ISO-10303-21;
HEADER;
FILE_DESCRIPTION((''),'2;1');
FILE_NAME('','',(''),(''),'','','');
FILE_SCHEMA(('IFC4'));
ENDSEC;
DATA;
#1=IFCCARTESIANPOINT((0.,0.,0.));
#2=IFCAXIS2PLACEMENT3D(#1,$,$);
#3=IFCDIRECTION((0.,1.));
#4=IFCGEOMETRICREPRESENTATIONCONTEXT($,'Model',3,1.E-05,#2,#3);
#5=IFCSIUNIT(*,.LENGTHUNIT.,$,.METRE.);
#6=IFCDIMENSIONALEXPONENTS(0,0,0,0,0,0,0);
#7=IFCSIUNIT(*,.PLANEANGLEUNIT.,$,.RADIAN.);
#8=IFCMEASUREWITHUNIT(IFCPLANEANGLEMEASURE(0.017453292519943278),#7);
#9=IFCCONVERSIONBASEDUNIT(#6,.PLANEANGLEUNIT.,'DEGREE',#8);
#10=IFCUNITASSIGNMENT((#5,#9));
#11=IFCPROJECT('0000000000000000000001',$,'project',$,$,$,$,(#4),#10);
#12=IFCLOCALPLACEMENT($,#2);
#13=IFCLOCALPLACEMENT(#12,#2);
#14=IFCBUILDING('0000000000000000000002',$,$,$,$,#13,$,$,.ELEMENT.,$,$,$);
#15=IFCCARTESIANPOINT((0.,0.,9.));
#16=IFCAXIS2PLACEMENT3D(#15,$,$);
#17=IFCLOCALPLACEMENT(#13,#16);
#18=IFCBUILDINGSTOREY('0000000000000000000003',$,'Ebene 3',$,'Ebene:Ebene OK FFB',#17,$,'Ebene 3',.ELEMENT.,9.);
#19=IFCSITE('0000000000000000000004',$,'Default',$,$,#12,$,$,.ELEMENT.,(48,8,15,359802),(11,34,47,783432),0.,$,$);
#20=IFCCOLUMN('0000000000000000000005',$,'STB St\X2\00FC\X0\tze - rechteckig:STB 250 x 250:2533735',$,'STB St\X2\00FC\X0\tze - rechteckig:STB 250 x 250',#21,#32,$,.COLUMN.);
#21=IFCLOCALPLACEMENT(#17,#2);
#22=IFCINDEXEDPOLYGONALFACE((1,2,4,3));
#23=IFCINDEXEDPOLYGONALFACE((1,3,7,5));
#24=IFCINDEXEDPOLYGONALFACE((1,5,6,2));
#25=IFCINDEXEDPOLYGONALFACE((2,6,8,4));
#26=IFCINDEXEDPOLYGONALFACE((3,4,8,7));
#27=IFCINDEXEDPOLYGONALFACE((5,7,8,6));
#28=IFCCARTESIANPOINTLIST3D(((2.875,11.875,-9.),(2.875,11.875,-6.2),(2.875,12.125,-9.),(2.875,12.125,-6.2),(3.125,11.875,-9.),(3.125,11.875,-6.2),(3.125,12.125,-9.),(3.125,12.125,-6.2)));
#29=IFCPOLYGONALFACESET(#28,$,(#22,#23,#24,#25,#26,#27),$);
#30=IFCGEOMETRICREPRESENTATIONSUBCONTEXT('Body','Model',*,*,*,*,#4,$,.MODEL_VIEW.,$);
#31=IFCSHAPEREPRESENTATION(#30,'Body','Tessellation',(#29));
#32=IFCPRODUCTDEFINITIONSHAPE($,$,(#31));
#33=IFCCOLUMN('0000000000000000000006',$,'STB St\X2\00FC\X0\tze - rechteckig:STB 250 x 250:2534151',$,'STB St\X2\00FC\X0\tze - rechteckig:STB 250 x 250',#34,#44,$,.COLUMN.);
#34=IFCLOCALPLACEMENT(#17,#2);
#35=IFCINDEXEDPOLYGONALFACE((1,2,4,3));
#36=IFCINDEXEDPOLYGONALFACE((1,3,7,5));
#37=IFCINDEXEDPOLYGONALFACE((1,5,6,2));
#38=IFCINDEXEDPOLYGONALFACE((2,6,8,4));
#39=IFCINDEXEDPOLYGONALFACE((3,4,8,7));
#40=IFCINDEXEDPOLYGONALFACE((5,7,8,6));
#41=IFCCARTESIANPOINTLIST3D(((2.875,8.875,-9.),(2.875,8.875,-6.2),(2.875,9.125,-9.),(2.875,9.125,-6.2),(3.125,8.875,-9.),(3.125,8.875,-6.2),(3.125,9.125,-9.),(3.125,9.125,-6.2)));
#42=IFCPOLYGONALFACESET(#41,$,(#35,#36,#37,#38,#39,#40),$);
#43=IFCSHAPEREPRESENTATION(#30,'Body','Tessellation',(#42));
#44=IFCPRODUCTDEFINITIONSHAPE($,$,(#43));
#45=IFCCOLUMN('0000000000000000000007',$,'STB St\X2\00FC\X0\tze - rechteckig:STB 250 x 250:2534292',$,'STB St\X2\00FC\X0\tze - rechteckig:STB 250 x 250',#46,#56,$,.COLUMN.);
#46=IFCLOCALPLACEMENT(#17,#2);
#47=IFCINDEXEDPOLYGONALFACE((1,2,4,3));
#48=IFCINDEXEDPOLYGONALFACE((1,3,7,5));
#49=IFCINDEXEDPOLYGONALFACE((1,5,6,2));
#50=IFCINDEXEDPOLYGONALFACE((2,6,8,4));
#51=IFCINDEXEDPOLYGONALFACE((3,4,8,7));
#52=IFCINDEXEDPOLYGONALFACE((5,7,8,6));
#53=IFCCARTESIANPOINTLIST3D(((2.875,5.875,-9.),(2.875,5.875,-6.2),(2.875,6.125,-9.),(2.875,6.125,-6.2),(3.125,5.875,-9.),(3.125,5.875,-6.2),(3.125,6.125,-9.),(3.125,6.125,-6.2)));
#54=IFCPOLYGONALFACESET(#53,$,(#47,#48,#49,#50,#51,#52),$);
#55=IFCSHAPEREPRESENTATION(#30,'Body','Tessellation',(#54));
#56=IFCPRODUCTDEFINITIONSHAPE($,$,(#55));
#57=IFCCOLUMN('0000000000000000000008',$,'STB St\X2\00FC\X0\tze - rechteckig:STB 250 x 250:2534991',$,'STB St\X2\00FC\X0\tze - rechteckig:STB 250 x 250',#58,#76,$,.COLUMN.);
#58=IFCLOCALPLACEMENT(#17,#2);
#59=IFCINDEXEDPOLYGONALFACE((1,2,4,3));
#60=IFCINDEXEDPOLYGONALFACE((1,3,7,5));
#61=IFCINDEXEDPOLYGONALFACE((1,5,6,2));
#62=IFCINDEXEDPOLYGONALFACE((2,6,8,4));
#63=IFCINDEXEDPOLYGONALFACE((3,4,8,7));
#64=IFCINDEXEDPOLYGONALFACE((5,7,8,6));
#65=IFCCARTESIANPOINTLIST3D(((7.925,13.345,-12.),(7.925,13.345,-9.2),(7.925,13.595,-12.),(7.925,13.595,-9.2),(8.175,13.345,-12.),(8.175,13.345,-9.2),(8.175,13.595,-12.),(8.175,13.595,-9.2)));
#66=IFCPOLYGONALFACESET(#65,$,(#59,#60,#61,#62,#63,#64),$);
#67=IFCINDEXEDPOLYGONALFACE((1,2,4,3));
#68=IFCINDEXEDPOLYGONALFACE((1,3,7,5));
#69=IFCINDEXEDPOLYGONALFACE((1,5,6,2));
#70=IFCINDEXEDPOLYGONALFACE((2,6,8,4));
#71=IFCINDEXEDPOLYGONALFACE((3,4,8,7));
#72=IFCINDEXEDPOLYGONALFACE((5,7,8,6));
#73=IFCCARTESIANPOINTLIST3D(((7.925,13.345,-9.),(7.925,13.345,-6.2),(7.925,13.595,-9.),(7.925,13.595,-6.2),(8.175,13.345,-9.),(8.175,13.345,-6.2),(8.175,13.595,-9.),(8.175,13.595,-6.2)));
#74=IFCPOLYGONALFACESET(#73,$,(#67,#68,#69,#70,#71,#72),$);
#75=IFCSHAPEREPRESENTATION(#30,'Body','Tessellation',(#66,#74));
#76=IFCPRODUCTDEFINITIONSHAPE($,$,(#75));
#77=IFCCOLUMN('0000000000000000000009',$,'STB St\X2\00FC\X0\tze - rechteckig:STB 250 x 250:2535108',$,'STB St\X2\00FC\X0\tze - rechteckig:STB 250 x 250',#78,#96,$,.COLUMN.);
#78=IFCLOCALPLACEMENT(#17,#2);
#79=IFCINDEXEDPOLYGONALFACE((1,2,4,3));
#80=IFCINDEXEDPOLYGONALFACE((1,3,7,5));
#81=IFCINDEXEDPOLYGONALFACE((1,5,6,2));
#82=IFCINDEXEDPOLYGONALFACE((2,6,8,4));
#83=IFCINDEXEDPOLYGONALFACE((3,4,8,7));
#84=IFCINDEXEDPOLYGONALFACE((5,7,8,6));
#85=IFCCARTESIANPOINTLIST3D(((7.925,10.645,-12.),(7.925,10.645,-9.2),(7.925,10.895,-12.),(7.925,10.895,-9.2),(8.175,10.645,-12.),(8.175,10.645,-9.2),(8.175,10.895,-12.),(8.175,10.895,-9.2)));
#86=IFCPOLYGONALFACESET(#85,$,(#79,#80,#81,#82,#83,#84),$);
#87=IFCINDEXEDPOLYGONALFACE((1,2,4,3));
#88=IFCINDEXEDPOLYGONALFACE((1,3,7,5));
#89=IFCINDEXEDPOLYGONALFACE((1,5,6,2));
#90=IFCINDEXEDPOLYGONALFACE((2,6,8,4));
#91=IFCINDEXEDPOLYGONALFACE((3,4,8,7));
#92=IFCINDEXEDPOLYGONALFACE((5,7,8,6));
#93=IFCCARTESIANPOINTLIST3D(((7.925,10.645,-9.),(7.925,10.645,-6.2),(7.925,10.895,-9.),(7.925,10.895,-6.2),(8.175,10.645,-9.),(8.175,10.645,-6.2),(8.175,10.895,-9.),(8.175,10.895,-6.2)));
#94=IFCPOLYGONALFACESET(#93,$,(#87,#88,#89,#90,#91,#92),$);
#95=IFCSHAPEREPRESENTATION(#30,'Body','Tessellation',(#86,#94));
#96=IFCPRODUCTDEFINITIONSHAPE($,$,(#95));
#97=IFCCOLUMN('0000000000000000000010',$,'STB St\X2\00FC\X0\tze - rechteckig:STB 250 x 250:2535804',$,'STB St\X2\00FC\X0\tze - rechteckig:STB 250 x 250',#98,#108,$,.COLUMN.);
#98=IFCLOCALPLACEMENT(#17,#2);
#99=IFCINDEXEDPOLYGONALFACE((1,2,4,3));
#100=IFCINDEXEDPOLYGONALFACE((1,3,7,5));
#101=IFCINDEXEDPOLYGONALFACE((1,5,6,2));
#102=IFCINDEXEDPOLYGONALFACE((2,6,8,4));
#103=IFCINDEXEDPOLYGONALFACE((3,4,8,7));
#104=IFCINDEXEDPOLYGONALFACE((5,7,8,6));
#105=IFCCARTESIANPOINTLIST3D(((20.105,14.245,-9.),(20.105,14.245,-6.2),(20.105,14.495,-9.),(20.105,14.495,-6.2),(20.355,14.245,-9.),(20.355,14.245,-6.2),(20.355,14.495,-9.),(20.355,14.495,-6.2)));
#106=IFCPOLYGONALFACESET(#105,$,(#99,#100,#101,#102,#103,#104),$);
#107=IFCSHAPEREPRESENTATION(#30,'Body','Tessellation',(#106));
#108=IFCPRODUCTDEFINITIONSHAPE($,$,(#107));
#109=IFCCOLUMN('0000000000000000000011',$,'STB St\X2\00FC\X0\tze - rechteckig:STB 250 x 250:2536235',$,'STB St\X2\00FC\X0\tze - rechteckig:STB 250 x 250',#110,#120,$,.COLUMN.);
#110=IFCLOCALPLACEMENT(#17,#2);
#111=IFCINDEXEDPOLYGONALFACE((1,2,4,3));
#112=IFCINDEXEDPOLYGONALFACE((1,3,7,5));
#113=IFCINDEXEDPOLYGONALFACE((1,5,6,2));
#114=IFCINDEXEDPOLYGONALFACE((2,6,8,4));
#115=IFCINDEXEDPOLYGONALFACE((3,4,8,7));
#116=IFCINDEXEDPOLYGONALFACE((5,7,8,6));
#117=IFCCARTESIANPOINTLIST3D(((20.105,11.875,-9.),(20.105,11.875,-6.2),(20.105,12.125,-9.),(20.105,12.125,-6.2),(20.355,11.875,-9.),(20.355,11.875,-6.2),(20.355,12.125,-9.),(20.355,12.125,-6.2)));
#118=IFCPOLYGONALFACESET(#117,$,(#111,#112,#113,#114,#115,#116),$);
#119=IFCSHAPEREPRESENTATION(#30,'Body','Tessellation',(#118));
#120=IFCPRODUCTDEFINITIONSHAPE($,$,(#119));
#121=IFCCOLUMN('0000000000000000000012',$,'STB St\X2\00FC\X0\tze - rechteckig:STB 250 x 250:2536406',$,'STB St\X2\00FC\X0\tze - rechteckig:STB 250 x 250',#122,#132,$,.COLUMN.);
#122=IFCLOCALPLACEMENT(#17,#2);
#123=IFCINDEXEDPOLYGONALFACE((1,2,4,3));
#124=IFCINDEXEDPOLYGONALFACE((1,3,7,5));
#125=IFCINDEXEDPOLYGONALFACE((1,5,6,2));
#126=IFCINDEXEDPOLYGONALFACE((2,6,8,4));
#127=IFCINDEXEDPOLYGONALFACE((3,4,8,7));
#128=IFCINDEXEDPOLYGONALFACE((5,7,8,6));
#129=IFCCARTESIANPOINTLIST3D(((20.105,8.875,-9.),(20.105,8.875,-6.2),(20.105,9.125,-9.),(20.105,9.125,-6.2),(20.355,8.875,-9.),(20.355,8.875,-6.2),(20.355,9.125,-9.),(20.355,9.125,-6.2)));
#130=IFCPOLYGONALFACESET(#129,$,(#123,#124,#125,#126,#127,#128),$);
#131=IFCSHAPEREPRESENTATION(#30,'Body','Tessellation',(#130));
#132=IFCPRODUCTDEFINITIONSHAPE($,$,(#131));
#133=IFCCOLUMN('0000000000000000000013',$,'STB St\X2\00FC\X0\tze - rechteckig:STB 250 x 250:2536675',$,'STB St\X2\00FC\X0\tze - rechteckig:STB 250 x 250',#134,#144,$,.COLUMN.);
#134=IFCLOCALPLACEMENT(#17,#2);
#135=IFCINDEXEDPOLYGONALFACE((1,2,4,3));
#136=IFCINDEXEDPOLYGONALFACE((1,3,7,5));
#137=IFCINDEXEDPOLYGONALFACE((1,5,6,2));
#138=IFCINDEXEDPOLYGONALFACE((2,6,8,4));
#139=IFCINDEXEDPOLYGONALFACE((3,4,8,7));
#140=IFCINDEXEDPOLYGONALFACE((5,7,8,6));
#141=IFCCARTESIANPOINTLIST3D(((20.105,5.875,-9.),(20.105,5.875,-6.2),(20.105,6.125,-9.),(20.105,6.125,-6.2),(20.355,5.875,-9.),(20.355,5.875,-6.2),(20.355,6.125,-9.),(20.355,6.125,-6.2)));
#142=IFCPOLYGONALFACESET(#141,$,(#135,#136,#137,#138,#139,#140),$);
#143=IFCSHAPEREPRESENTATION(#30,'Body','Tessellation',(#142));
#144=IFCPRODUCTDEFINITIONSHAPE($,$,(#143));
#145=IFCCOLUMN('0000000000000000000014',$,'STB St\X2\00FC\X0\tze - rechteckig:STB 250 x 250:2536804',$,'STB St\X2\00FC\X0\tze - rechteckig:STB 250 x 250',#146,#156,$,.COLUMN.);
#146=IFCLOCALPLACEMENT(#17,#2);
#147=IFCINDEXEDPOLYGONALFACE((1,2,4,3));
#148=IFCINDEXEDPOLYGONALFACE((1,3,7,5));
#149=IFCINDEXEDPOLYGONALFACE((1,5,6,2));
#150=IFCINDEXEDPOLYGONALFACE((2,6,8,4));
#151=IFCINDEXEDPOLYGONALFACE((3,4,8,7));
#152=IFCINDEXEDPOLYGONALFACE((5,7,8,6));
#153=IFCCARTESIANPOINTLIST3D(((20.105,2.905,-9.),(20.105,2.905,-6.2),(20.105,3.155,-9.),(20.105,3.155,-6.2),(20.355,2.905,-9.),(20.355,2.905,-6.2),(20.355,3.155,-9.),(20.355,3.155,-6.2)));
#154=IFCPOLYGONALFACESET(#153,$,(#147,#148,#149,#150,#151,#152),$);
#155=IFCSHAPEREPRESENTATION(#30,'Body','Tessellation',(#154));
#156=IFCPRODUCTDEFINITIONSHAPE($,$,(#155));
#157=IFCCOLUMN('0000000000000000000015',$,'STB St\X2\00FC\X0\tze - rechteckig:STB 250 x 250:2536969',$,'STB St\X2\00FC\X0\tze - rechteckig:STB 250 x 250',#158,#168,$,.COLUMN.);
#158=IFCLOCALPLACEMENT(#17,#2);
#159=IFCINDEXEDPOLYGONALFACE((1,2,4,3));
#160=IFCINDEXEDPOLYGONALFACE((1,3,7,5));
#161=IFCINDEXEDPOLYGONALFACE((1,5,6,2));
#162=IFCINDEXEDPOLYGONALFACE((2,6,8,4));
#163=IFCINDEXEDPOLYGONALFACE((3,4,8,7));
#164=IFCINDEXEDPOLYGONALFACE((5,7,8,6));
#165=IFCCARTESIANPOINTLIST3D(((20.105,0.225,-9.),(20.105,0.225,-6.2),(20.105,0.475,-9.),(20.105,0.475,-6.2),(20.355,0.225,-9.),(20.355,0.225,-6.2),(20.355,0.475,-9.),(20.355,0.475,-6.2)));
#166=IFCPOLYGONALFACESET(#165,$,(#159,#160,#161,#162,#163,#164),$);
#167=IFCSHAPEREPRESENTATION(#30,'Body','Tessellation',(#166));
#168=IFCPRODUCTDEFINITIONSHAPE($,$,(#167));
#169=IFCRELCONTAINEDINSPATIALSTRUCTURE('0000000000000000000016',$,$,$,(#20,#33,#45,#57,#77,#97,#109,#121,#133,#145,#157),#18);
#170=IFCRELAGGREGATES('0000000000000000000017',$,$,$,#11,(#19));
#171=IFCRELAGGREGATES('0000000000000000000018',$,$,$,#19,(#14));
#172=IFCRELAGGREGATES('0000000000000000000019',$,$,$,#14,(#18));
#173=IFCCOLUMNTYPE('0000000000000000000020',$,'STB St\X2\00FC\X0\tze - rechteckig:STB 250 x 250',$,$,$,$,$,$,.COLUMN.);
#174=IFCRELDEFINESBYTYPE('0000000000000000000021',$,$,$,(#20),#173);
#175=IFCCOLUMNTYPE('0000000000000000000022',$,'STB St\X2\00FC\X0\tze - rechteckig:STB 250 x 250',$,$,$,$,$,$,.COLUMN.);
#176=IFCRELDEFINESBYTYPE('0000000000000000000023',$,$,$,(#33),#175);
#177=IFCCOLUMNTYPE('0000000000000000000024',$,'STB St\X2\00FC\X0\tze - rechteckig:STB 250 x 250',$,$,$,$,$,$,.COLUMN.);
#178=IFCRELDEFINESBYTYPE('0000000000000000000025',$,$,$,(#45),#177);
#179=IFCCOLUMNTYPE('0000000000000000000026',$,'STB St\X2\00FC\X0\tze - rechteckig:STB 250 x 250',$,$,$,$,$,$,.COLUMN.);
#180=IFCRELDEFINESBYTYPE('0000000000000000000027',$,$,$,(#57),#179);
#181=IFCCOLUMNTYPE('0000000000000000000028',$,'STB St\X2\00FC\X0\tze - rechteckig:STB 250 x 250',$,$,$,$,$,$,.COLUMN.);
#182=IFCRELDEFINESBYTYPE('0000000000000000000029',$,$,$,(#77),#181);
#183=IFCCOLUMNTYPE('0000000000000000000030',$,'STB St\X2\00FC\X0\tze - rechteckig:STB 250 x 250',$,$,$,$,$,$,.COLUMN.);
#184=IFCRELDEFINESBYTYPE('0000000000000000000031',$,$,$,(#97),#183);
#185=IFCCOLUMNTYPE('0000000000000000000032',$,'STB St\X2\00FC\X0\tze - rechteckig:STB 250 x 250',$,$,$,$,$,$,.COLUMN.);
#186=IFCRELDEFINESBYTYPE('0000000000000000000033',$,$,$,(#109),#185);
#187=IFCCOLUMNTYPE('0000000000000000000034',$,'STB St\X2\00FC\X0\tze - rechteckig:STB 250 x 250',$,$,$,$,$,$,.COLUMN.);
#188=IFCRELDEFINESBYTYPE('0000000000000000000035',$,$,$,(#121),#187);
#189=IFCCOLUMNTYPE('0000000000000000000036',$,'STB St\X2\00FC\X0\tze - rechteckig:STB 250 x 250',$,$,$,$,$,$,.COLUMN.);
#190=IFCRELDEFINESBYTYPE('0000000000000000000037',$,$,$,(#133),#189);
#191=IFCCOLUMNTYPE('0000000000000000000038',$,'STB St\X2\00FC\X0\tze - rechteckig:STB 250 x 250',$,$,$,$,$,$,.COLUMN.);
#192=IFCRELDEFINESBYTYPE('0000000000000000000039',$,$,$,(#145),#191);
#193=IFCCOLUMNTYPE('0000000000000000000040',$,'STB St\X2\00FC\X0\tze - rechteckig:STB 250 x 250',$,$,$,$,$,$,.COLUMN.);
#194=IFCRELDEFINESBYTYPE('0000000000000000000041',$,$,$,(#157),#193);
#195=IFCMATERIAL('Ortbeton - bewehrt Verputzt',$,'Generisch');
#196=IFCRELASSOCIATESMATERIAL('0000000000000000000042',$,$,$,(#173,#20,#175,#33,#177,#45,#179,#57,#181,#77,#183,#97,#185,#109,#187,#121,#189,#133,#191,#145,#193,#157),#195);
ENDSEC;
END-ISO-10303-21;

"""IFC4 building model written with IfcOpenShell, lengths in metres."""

from ifc_helpers import new_model, entity, si_unit, converted_unit, direction, frame, origin, place, context, subcontext, project, spatial, indexed_curve, outline, extrude, source, transform, mapped, material, type_object, type_shapes, element, save


model = new_model("IFC4")

# Units and contexts
model_context = context("Model", 3, precision=1e-05, world=origin(), true_north=direction((0.0, 1.0)))
body_context = subcontext(model_context, "Body", "Model", "MODEL_VIEW")
ifc_project = project(units=[si_unit("LENGTHUNIT", "METRE"), converted_unit("PLANEANGLEUNIT", "DEGREE", entity("IfcPlaneAngleMeasure", 0.017453292519943278), si_unit("PLANEANGLEUNIT", "RADIAN"), dimensions=[0, 0, 0, 0, 0, 0, 0])], contexts=[model_context])

# Site, building, storey
site_placement = place(None, origin())
site = spatial("IfcSite", under=ifc_project, at=site_placement, Name="Default", CompositionType="ELEMENT", RefLatitude=(48, 8, 15, 359802), RefLongitude=(11, 34, 47, 783432), RefElevation=0.0)
building_placement = place(site_placement, origin())
building = spatial("IfcBuilding", under=site, at=building_placement, CompositionType="ELEMENT")
storey_placement = place(building_placement, frame((0.0, 0.0, 9.0)))
storey = spatial("IfcBuildingStorey", under=building, at=storey_placement, Name="Ebene 3", ObjectType="Ebene:Ebene OK FFB", LongName="Ebene 3", CompositionType="ELEMENT", Elevation=9.0)

# Columns
ifc_material_1 = material(Name="Ortbeton - bewehrt Verputzt", Category="Generisch")
column_type_1 = type_object("IfcColumnType", Name="STB Stütze - rechteckig:STB 250 x 250", PredefinedType="COLUMN", material=ifc_material_1)
shared_shape_1 = source(origin(), body_context, "Body", "SweptSolid", [
    extrude(outline(indexed_curve([(-0.125, -0.125), (0.125, -0.125), (0.125, 0.125), (-0.125, 0.125), (-0.125, -0.125)], self_intersect=False)), frame((3.0, 12.0, 0.0), z_axis=(0.0, 0.0, 1.0), x_axis=(-1.0, 0.0, 0.0)), (0.0, 0.0, 1.0), 2.8),
])
type_shapes(column_type_1, [shared_shape_1])
column_1_placement = place(storey_placement, frame((0.0, 0.0, -9.0)))
element("IfcColumn", 1, at=column_1_placement, inside=storey, type_object=column_type_1, material=ifc_material_1, Name="STB Stütze - rechteckig:STB 250 x 250:2533735", ObjectType="STB Stütze - rechteckig:STB 250 x 250", PredefinedType="COLUMN", context=body_context, shape_type="MappedRepresentation", body=[
    mapped(shared_shape_1, transform((0.0, 0.0, 0.0), scale=1.0)),
])
column_type_2 = type_object("IfcColumnType", Name="STB Stütze - rechteckig:STB 250 x 250", PredefinedType="COLUMN", material=ifc_material_1)
shared_shape_2 = source(origin(), body_context, "Body", "SweptSolid", [
    extrude(outline(indexed_curve([(-0.125, -0.125), (0.125, -0.125), (0.125, 0.125), (-0.125, 0.125), (-0.125, -0.125)], self_intersect=False)), frame((3.0, 9.0, 0.0), z_axis=(0.0, 0.0, 1.0), x_axis=(-1.0, 0.0, 0.0)), (0.0, 0.0, 1.0), 2.8),
])
type_shapes(column_type_2, [shared_shape_2])
column_2_placement = place(storey_placement, frame((0.0, 0.0, -9.0)))
element("IfcColumn", 2, at=column_2_placement, inside=storey, type_object=column_type_2, material=ifc_material_1, Name="STB Stütze - rechteckig:STB 250 x 250:2534151", ObjectType="STB Stütze - rechteckig:STB 250 x 250", PredefinedType="COLUMN", context=body_context, shape_type="MappedRepresentation", body=[
    mapped(shared_shape_2, transform((0.0, 0.0, 0.0), scale=1.0)),
])
column_type_3 = type_object("IfcColumnType", Name="STB Stütze - rechteckig:STB 250 x 250", PredefinedType="COLUMN", material=ifc_material_1)
shared_shape_3 = source(origin(), body_context, "Body", "SweptSolid", [
    extrude(outline(indexed_curve([(-0.125, -0.125), (0.125, -0.125), (0.125, 0.125), (-0.125, 0.125), (-0.125, -0.125)], self_intersect=False)), frame((3.0, 6.0, 0.0), z_axis=(0.0, 0.0, 1.0), x_axis=(-1.0, 0.0, 0.0)), (0.0, 0.0, 1.0), 2.8),
])
type_shapes(column_type_3, [shared_shape_3])
column_3_placement = place(storey_placement, frame((0.0, 0.0, -9.0)))
element("IfcColumn", 3, at=column_3_placement, inside=storey, type_object=column_type_3, material=ifc_material_1, Name="STB Stütze - rechteckig:STB 250 x 250:2534292", ObjectType="STB Stütze - rechteckig:STB 250 x 250", PredefinedType="COLUMN", context=body_context, shape_type="MappedRepresentation", body=[
    mapped(shared_shape_3, transform((0.0, 0.0, 0.0), scale=1.0)),
])
column_type_4 = type_object("IfcColumnType", Name="STB Stütze - rechteckig:STB 250 x 250", PredefinedType="COLUMN", material=ifc_material_1)
shared_shape_4 = source(origin(), body_context, "Body", "SweptSolid", [
    extrude(outline(indexed_curve([(-0.125, -0.125), (0.125, -0.125), (0.125, 0.125), (-0.125, 0.125), (-0.125, -0.125)], self_intersect=False)), frame((8.05, 13.47, -3.0), z_axis=(0.0, 0.0, 1.0), x_axis=(-1.0, 0.0, 0.0)), (0.0, 0.0, 1.0), 2.8),
    extrude(outline(indexed_curve([(-0.125, -0.125), (0.125, -0.125), (0.125, 0.125), (-0.125, 0.125), (-0.125, -0.125)], self_intersect=False)), frame((8.05, 13.47, 0.0), z_axis=(0.0, 0.0, 1.0), x_axis=(0.0, -1.0, 0.0)), (0.0, 0.0, 1.0), 2.8),
])
type_shapes(column_type_4, [shared_shape_4])
column_4_placement = place(storey_placement, frame((0.0, 0.0, -9.0)))
element("IfcColumn", 4, at=column_4_placement, inside=storey, type_object=column_type_4, material=ifc_material_1, Name="STB Stütze - rechteckig:STB 250 x 250:2534991", ObjectType="STB Stütze - rechteckig:STB 250 x 250", PredefinedType="COLUMN", context=body_context, shape_type="MappedRepresentation", body=[
    mapped(shared_shape_4, transform((0.0, 0.0, 0.0), scale=1.0)),
])
column_type_5 = type_object("IfcColumnType", Name="STB Stütze - rechteckig:STB 250 x 250", PredefinedType="COLUMN", material=ifc_material_1)
shared_shape_5 = source(origin(), body_context, "Body", "SweptSolid", [
    extrude(outline(indexed_curve([(-0.125, -0.125), (0.125, -0.125), (0.125, 0.125), (-0.125, 0.125), (-0.125, -0.125)], self_intersect=False)), frame((8.05, 10.77, -3.0), z_axis=(0.0, 0.0, 1.0), x_axis=(-1.0, 0.0, 0.0)), (0.0, 0.0, 1.0), 2.8),
    extrude(outline(indexed_curve([(-0.125, -0.125), (0.125, -0.125), (0.125, 0.125), (-0.125, 0.125), (-0.125, -0.125)], self_intersect=False)), frame((8.05, 10.77, 0.0), z_axis=(0.0, 0.0, 1.0), x_axis=(0.0, -1.0, 0.0)), (0.0, 0.0, 1.0), 2.8),
])
type_shapes(column_type_5, [shared_shape_5])
column_5_placement = place(storey_placement, frame((0.0, 0.0, -9.0)))
element("IfcColumn", 5, at=column_5_placement, inside=storey, type_object=column_type_5, material=ifc_material_1, Name="STB Stütze - rechteckig:STB 250 x 250:2535108", ObjectType="STB Stütze - rechteckig:STB 250 x 250", PredefinedType="COLUMN", context=body_context, shape_type="MappedRepresentation", body=[
    mapped(shared_shape_5, transform((0.0, 0.0, 0.0), scale=1.0)),
])
column_type_6 = type_object("IfcColumnType", Name="STB Stütze - rechteckig:STB 250 x 250", PredefinedType="COLUMN", material=ifc_material_1)
shared_shape_6 = source(origin(), body_context, "Body", "SweptSolid", [
    extrude(outline(indexed_curve([(-0.125, -0.125), (0.125, -0.125), (0.125, 0.125), (-0.125, 0.125), (-0.125, -0.125)], self_intersect=False)), frame((20.23, 14.37, 0.0), z_axis=(0.0, 0.0, 1.0), x_axis=(-1.0, 0.0, 0.0)), (0.0, 0.0, 1.0), 2.8),
])
type_shapes(column_type_6, [shared_shape_6])
column_6_placement = place(storey_placement, frame((0.0, 0.0, -9.0)))
element("IfcColumn", 6, at=column_6_placement, inside=storey, type_object=column_type_6, material=ifc_material_1, Name="STB Stütze - rechteckig:STB 250 x 250:2535804", ObjectType="STB Stütze - rechteckig:STB 250 x 250", PredefinedType="COLUMN", context=body_context, shape_type="MappedRepresentation", body=[
    mapped(shared_shape_6, transform((0.0, 0.0, 0.0), scale=1.0)),
])
column_type_7 = type_object("IfcColumnType", Name="STB Stütze - rechteckig:STB 250 x 250", PredefinedType="COLUMN", material=ifc_material_1)
shared_shape_7 = source(origin(), body_context, "Body", "SweptSolid", [
    extrude(outline(indexed_curve([(-0.125, -0.125), (0.125, -0.125), (0.125, 0.125), (-0.125, 0.125), (-0.125, -0.125)], self_intersect=False)), frame((20.23, 12.0, 0.0), z_axis=(0.0, 0.0, 1.0), x_axis=(-1.0, 0.0, 0.0)), (0.0, 0.0, 1.0), 2.8),
])
type_shapes(column_type_7, [shared_shape_7])
column_7_placement = place(storey_placement, frame((0.0, 0.0, -9.0)))
element("IfcColumn", 7, at=column_7_placement, inside=storey, type_object=column_type_7, material=ifc_material_1, Name="STB Stütze - rechteckig:STB 250 x 250:2536235", ObjectType="STB Stütze - rechteckig:STB 250 x 250", PredefinedType="COLUMN", context=body_context, shape_type="MappedRepresentation", body=[
    mapped(shared_shape_7, transform((0.0, 0.0, 0.0), scale=1.0)),
])
column_type_8 = type_object("IfcColumnType", Name="STB Stütze - rechteckig:STB 250 x 250", PredefinedType="COLUMN", material=ifc_material_1)
shared_shape_8 = source(origin(), body_context, "Body", "SweptSolid", [
    extrude(outline(indexed_curve([(-0.125, -0.125), (0.125, -0.125), (0.125, 0.125), (-0.125, 0.125), (-0.125, -0.125)], self_intersect=False)), frame((20.23, 9.0, 0.0), z_axis=(0.0, 0.0, 1.0), x_axis=(-1.0, 0.0, 0.0)), (0.0, 0.0, 1.0), 2.8),
])
type_shapes(column_type_8, [shared_shape_8])
column_8_placement = place(storey_placement, frame((0.0, 0.0, -9.0)))
element("IfcColumn", 8, at=column_8_placement, inside=storey, type_object=column_type_8, material=ifc_material_1, Name="STB Stütze - rechteckig:STB 250 x 250:2536406", ObjectType="STB Stütze - rechteckig:STB 250 x 250", PredefinedType="COLUMN", context=body_context, shape_type="MappedRepresentation", body=[
    mapped(shared_shape_8, transform((0.0, 0.0, 0.0), scale=1.0)),
])
column_type_9 = type_object("IfcColumnType", Name="STB Stütze - rechteckig:STB 250 x 250", PredefinedType="COLUMN", material=ifc_material_1)
shared_shape_9 = source(origin(), body_context, "Body", "SweptSolid", [
    extrude(outline(indexed_curve([(-0.125, -0.125), (0.125, -0.125), (0.125, 0.125), (-0.125, 0.125), (-0.125, -0.125)], self_intersect=False)), frame((20.23, 6.0, 0.0), z_axis=(0.0, 0.0, 1.0), x_axis=(-1.0, 0.0, 0.0)), (0.0, 0.0, 1.0), 2.8),
])
type_shapes(column_type_9, [shared_shape_9])
column_9_placement = place(storey_placement, frame((0.0, 0.0, -9.0)))
element("IfcColumn", 9, at=column_9_placement, inside=storey, type_object=column_type_9, material=ifc_material_1, Name="STB Stütze - rechteckig:STB 250 x 250:2536675", ObjectType="STB Stütze - rechteckig:STB 250 x 250", PredefinedType="COLUMN", context=body_context, shape_type="MappedRepresentation", body=[
    mapped(shared_shape_9, transform((0.0, 0.0, 0.0), scale=1.0)),
])
column_type_10 = type_object("IfcColumnType", Name="STB Stütze - rechteckig:STB 250 x 250", PredefinedType="COLUMN", material=ifc_material_1)
shared_shape_10 = source(origin(), body_context, "Body", "SweptSolid", [
    extrude(outline(indexed_curve([(-0.125, -0.125), (0.125, -0.125), (0.125, 0.125), (-0.125, 0.125), (-0.125, -0.125)], self_intersect=False)), frame((20.23, 3.03, 0.0), z_axis=(0.0, 0.0, 1.0), x_axis=(-1.0, 0.0, 0.0)), (0.0, 0.0, 1.0), 2.8),
])
type_shapes(column_type_10, [shared_shape_10])
column_10_placement = place(storey_placement, frame((0.0, 0.0, -9.0)))
element("IfcColumn", 10, at=column_10_placement, inside=storey, type_object=column_type_10, material=ifc_material_1, Name="STB Stütze - rechteckig:STB 250 x 250:2536804", ObjectType="STB Stütze - rechteckig:STB 250 x 250", PredefinedType="COLUMN", context=body_context, shape_type="MappedRepresentation", body=[
    mapped(shared_shape_10, transform((0.0, 0.0, 0.0), scale=1.0)),
])
column_type_11 = type_object("IfcColumnType", Name="STB Stütze - rechteckig:STB 250 x 250", PredefinedType="COLUMN", material=ifc_material_1)
shared_shape_11 = source(origin(), body_context, "Body", "SweptSolid", [
    extrude(outline(indexed_curve([(-0.125, -0.125), (0.125, -0.125), (0.125, 0.125), (-0.125, 0.125), (-0.125, -0.125)], self_intersect=False)), frame((20.23, 0.35, 0.0), z_axis=(0.0, 0.0, 1.0), x_axis=(-1.0, 0.0, 0.0)), (0.0, 0.0, 1.0), 2.8),
])
type_shapes(column_type_11, [shared_shape_11])
column_11_placement = place(storey_placement, frame((0.0, 0.0, -9.0)))
element("IfcColumn", 11, at=column_11_placement, inside=storey, type_object=column_type_11, material=ifc_material_1, Name="STB Stütze - rechteckig:STB 250 x 250:2536969", ObjectType="STB Stütze - rechteckig:STB 250 x 250", PredefinedType="COLUMN", context=body_context, shape_type="MappedRepresentation", body=[
    mapped(shared_shape_11, transform((0.0, 0.0, 0.0), scale=1.0)),
])

save(model, "model.ifc")
